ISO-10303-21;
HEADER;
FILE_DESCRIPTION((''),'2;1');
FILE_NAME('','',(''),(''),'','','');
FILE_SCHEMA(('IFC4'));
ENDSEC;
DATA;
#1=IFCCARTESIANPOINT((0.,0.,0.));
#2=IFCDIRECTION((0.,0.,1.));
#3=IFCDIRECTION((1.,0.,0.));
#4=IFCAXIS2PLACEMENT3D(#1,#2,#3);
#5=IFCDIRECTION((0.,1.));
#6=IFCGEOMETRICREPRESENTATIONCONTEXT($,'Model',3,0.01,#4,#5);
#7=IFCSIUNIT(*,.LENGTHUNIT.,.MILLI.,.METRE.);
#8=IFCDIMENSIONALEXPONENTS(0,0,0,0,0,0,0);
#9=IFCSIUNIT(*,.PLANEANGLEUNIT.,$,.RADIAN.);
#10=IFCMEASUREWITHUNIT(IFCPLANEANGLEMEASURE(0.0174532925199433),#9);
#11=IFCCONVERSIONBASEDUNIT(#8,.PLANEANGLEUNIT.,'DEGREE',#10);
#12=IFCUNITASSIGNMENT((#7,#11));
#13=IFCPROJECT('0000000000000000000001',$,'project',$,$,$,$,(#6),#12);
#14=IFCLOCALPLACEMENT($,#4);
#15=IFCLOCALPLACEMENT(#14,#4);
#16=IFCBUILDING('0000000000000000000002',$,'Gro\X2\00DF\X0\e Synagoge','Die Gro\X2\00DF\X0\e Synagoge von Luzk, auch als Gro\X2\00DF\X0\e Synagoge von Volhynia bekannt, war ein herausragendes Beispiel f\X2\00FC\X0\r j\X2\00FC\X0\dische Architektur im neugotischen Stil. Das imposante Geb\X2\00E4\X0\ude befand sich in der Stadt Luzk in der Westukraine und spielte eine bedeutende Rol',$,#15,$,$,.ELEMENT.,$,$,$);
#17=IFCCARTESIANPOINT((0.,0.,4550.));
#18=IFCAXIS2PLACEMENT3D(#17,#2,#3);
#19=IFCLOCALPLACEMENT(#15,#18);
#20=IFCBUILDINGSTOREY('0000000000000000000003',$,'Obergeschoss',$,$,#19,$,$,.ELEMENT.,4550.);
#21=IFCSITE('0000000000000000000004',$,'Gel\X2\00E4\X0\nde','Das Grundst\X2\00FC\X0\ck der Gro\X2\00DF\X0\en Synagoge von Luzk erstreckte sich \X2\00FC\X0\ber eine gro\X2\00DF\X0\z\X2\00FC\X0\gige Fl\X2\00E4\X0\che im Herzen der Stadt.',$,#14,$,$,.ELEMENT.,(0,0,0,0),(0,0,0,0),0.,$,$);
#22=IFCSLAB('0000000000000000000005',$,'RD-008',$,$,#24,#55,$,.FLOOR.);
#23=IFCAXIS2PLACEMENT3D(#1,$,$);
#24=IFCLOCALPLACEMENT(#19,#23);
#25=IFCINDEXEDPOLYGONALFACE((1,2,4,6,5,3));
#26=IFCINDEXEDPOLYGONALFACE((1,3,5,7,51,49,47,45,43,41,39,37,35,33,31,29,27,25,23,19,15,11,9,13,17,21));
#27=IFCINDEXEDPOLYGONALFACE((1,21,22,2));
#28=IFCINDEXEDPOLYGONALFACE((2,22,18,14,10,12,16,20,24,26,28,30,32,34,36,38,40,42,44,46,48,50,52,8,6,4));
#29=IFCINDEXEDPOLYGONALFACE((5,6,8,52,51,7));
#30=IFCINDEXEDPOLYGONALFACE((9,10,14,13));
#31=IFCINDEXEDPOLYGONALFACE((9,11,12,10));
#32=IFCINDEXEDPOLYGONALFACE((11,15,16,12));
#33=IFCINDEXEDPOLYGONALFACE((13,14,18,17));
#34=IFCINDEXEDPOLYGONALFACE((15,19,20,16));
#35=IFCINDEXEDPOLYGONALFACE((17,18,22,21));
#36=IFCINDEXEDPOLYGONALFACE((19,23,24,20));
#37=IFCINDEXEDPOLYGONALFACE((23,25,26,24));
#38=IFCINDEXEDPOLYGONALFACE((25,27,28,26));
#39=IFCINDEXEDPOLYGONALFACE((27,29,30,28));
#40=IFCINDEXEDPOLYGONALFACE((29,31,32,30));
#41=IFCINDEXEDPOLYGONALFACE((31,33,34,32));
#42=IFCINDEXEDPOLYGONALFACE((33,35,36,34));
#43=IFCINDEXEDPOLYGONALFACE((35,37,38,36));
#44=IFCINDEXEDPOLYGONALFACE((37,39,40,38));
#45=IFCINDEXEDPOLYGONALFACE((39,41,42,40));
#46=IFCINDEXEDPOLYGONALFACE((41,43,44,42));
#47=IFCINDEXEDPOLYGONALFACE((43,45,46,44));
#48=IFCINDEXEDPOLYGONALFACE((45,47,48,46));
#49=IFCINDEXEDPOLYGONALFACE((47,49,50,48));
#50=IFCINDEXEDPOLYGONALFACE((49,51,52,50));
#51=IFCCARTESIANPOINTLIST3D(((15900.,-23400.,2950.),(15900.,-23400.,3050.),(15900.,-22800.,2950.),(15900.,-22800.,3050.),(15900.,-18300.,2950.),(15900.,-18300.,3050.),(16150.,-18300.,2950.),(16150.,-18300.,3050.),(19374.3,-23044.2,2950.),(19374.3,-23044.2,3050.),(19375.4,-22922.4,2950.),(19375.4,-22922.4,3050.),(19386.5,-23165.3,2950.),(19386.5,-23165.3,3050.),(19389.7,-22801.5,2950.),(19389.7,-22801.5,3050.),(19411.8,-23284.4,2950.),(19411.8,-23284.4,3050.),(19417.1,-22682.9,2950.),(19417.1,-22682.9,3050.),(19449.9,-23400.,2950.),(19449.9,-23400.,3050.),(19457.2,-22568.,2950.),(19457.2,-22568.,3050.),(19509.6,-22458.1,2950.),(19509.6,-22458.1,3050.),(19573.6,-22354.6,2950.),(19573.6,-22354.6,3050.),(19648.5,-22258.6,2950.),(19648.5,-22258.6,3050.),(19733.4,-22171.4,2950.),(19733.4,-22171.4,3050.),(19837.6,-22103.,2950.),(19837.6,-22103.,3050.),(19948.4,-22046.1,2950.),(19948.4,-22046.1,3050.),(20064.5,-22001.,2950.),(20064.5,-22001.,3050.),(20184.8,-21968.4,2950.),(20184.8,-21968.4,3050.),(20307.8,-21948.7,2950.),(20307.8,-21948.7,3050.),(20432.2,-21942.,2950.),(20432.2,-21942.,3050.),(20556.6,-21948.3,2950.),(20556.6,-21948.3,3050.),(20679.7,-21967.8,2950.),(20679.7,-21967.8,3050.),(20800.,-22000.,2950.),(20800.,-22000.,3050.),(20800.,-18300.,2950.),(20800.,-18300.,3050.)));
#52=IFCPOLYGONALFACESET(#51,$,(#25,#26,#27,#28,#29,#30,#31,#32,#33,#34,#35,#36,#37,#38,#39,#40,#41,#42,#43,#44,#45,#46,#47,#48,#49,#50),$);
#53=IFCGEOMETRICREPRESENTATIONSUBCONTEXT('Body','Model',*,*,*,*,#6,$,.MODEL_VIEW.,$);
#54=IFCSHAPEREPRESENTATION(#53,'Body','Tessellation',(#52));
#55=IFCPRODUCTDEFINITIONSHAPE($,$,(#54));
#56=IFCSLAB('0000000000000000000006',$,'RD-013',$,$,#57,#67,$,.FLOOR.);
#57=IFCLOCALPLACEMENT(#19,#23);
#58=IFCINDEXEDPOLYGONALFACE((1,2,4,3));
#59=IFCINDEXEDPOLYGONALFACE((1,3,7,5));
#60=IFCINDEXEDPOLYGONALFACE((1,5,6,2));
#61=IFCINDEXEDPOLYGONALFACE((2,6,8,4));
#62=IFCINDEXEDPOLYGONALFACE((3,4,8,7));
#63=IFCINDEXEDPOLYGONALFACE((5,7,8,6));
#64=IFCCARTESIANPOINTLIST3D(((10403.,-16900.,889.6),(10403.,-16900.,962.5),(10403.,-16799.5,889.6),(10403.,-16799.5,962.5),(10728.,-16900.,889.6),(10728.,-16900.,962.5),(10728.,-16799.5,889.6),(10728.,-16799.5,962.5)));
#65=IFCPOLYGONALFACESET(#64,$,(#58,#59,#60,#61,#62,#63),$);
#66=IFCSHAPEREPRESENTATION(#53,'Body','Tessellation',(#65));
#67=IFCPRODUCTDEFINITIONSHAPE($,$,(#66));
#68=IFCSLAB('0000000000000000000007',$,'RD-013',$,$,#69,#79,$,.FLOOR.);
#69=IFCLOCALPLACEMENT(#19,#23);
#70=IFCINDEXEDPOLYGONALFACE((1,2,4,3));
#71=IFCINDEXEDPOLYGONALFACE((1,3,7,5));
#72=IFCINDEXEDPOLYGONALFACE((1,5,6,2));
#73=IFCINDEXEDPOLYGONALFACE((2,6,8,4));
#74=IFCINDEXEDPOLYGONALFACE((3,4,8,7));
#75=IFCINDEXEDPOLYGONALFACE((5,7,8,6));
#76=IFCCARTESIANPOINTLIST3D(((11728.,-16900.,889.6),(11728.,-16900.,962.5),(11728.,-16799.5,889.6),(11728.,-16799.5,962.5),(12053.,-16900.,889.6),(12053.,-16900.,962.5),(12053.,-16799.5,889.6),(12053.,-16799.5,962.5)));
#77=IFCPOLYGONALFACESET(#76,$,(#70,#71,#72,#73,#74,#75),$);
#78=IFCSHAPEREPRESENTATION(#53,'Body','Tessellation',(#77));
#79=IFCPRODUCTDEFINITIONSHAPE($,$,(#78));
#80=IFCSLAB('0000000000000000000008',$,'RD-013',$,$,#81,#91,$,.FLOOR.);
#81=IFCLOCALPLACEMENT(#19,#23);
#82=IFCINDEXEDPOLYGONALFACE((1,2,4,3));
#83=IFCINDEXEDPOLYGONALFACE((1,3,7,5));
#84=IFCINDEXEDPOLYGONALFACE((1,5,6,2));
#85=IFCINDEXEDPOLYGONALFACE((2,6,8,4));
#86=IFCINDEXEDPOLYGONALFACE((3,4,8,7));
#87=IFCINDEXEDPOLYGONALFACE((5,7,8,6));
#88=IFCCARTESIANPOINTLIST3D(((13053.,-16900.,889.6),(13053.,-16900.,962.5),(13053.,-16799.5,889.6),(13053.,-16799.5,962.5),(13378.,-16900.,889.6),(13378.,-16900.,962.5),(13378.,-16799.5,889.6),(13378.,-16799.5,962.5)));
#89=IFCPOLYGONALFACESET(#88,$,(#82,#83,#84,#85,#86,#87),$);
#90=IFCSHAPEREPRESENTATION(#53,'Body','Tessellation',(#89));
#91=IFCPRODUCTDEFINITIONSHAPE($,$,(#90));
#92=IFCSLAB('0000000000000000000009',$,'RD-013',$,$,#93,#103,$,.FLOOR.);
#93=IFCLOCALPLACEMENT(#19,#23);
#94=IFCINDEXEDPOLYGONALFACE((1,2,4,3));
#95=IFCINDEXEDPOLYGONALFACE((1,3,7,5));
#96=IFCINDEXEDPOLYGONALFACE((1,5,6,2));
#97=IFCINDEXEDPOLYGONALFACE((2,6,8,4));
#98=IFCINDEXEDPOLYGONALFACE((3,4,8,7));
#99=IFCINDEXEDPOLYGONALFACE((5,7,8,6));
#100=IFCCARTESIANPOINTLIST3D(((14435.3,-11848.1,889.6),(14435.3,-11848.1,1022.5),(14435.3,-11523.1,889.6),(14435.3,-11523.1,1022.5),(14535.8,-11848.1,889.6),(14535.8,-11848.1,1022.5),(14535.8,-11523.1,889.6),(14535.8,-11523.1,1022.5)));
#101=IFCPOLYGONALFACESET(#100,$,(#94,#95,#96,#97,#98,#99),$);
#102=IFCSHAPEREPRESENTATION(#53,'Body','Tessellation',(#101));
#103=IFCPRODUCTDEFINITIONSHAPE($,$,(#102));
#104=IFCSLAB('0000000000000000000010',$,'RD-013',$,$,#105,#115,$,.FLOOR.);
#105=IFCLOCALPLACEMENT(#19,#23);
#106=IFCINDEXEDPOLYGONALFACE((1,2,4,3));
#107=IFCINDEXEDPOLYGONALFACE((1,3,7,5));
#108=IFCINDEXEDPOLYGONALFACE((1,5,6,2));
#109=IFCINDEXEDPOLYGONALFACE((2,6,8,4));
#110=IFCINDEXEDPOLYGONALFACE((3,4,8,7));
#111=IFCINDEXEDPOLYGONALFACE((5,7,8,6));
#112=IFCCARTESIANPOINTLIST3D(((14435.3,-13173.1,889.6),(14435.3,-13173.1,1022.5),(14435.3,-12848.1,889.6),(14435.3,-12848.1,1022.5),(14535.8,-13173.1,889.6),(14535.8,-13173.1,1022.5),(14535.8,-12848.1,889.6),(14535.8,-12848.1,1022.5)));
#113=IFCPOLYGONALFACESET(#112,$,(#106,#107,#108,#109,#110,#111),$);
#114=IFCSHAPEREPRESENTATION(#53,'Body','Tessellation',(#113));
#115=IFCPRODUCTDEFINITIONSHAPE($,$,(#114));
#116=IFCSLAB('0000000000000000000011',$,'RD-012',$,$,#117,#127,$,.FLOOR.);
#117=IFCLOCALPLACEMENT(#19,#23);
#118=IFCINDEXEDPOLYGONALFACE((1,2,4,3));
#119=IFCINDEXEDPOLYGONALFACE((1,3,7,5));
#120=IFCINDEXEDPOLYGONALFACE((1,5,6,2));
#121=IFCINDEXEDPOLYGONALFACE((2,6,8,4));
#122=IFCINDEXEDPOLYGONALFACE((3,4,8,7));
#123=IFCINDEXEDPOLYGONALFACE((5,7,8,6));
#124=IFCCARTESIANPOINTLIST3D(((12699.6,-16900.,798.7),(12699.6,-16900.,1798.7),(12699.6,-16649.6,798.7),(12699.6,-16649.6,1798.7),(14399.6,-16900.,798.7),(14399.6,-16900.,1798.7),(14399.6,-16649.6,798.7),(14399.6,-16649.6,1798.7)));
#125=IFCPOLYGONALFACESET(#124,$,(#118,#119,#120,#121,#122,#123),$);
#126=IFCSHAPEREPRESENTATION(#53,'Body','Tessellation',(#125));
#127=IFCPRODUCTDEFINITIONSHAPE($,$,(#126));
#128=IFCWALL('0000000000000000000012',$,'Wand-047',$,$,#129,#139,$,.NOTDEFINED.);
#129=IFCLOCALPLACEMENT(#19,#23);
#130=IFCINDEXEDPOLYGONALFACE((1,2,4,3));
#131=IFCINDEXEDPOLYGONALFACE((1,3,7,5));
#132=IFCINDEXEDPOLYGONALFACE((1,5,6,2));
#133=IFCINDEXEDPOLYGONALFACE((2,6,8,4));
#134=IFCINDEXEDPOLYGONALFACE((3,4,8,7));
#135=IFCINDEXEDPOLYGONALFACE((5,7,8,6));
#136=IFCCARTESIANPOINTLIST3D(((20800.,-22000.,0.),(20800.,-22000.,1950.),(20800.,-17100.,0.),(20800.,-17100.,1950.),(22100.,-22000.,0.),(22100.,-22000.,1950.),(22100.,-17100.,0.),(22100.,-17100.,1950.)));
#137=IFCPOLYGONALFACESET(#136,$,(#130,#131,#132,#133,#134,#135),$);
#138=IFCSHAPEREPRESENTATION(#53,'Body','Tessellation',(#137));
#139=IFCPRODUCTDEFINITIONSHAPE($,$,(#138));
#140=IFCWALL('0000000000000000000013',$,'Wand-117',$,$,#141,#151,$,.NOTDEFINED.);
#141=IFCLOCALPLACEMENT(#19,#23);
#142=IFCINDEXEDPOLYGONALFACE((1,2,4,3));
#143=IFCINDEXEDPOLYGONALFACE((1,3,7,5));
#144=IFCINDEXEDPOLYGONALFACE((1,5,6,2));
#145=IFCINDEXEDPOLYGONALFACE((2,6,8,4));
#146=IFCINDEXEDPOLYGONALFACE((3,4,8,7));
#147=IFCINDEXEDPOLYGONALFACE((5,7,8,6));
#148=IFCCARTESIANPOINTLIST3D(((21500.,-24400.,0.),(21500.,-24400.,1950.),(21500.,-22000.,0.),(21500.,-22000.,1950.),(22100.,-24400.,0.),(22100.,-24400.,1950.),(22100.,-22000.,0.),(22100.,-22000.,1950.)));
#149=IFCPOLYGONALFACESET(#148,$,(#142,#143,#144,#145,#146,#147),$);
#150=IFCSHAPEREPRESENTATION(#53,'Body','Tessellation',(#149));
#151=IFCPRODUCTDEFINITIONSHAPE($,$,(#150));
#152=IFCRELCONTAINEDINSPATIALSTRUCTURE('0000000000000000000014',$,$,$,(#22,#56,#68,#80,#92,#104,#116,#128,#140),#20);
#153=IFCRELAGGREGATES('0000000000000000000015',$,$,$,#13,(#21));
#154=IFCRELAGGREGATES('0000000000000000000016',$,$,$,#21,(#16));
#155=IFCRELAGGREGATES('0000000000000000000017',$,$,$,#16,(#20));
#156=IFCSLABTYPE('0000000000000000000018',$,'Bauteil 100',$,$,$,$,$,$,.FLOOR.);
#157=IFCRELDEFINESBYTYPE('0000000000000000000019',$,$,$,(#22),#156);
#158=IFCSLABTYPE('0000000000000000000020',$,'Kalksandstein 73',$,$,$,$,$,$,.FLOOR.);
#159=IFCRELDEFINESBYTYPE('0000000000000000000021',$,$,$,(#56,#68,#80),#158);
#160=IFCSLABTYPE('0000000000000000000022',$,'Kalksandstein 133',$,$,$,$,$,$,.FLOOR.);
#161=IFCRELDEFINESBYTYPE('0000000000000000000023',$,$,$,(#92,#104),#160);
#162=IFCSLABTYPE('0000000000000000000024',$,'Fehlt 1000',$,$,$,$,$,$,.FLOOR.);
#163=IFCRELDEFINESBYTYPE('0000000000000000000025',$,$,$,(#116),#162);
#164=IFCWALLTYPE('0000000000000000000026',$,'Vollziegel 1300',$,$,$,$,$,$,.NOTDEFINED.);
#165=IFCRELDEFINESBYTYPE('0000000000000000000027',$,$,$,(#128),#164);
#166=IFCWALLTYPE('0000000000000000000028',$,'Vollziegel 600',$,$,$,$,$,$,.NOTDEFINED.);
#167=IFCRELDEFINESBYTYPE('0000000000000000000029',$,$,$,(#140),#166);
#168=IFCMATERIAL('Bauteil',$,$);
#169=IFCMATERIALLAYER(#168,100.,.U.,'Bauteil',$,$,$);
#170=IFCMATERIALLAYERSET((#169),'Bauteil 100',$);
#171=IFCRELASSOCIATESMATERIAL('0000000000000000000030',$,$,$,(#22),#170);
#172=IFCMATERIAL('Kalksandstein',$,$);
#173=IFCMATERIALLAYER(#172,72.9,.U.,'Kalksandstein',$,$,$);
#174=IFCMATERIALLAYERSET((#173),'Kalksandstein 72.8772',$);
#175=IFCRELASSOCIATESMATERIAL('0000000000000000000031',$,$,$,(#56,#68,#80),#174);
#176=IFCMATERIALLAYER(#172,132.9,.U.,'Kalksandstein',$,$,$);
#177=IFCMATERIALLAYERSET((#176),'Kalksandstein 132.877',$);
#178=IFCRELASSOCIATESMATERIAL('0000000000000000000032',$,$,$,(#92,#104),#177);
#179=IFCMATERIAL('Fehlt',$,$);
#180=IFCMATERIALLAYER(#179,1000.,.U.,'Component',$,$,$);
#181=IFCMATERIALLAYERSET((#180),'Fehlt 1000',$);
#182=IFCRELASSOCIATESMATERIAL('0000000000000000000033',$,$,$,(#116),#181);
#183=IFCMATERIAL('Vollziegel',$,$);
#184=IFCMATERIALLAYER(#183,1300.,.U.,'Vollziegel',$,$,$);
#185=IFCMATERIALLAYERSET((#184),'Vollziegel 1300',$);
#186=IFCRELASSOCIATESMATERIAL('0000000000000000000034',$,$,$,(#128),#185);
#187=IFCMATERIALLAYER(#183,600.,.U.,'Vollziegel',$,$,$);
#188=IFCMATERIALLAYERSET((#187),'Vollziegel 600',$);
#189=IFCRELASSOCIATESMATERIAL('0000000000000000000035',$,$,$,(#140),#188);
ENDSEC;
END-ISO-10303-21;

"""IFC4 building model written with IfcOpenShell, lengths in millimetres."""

from ifc_helpers import new_model, entity, si_unit, converted_unit, direction, frame, origin_with_axes, place, context, subcontext, project, spatial, line, arc, indexed_curve, outline, extrude, material, layer, layer_set, layer_usage, type_object, element, save


model = new_model("IFC4")

# Units and contexts
model_context = context("Model", 3, precision=0.01, world=origin_with_axes(), true_north=direction((0.0, 1.0)))
body_context = subcontext(model_context, "Body", "Model", "MODEL_VIEW")
ifc_project = project(units=[si_unit("LENGTHUNIT", "METRE", prefix="MILLI"), converted_unit("PLANEANGLEUNIT", "DEGREE", entity("IfcPlaneAngleMeasure", 0.0174532925199433), si_unit("PLANEANGLEUNIT", "RADIAN"), dimensions=[0, 0, 0, 0, 0, 0, 0])], contexts=[model_context])

# Site, building, storey
site_placement = place(None, origin_with_axes())
site = spatial("IfcSite", under=ifc_project, at=site_placement, Name="Gelände", Description="Das Grundstück der Großen Synagoge von Luzk erstreckte sich über eine großzügige Fläche im Herzen der Stadt.", CompositionType="ELEMENT", RefLatitude=(0, 0, 0, 0), RefLongitude=(0, 0, 0, 0), RefElevation=0.0)
building_placement = place(site_placement, origin_with_axes())
building = spatial("IfcBuilding", under=site, at=building_placement, Name="Große Synagoge", Description="Die Große Synagoge von Luzk, auch als Große Synagoge von Volhynia bekannt, war ein herausragendes Beispiel für jüdische Architektur im neugotischen Stil. Das imposante Gebäude befand sich in der Stadt Luzk in der Westukraine und spielte eine bedeutende Rol", CompositionType="ELEMENT")
storey_placement = place(building_placement, frame((0.0, 0.0, 4550.0), z_axis=(0.0, 0.0, 1.0), x_axis=(1.0, 0.0, 0.0)))
storey = spatial("IfcBuildingStorey", under=building, at=storey_placement, Name="Obergeschoss", CompositionType="ELEMENT", Elevation=4550.0)

# Shared definitions
ifc_material_1 = material(Name="Kalksandstein")

# Slabs
ifc_material_2 = material(Name="Bauteil")
ifc_layer_1 = layer(ifc_material_2, 100.0, ventilated="UNKNOWN", Name="Bauteil")
ifc_layer_set_1 = layer_set([ifc_layer_1], Name="Bauteil 100")
ifc_layer_usage_1 = layer_usage(ifc_layer_set_1, "AXIS3", "NEGATIVE", 100.0)
slab_type_1 = type_object("IfcSlabType", Name="Bauteil 100", PredefinedType="FLOOR")
slab_1_placement = place(storey_placement, frame((15900.0, -18300.0, 3050.0), z_axis=(0.0, 0.0, 1.0), x_axis=(1.0, 0.0, 0.0)))
element("IfcSlab", 1, at=slab_1_placement, inside=storey, type_object=slab_type_1, material=ifc_layer_usage_1, Name="RD-008", PredefinedType="FLOOR", context=body_context, shape_type="SweptSolid", body=[
    extrude(outline(indexed_curve([(0.0, 0.0), (0.0, -4500.0), (0.0, -5100.0), (3549.9, -5100.0), (3501.8, -4441.9), (3833.4, -3871.4), (4346.0, -3656.9), (4900.0, -3700.0), (4900.0, 0.0), (250.0, 0.0)], segments=[line(1, 2, 3, 4), arc(4, 5, 6), arc(6, 7, 8), line(8, 9, 10, 1)])), frame((0.0, 0.0, -100.0), z_axis=(0.0, 0.0, 1.0), x_axis=(1.0, 0.0, 0.0)), (0.0, 0.0, 1.0), 100.0),
])
ifc_layer_2 = layer(ifc_material_1, 72.9, ventilated="UNKNOWN", Name="Kalksandstein")
ifc_layer_set_2 = layer_set([ifc_layer_2], Name="Kalksandstein 72.8772")
ifc_layer_usage_2 = layer_usage(ifc_layer_set_2, "AXIS3", "NEGATIVE", 72.9)
slab_type_2 = type_object("IfcSlabType", Name="Kalksandstein 73", PredefinedType="FLOOR")
slab_2_placement = place(storey_placement, frame((10403.0, -16900.0, 962.5), z_axis=(0.0, 0.0, 1.0), x_axis=(1.0, 0.0, 0.0)))
element("IfcSlab", 2, at=slab_2_placement, inside=storey, type_object=slab_type_2, material=ifc_layer_usage_2, Name="RD-013", PredefinedType="FLOOR", context=body_context, shape_type="SweptSolid", body=[
    extrude(outline(indexed_curve([(0.0, 0.0), (325.0, 0.0), (325.0, 100.5), (0.0, 100.5)], segments=[line(1, 2, 3, 4, 1)])), frame((0.0, 0.0, -72.9), z_axis=(0.0, 0.0, 1.0), x_axis=(1.0, 0.0, 0.0)), (0.0, 0.0, 1.0), 72.9),
])
ifc_layer_usage_3 = layer_usage(ifc_layer_set_2, "AXIS3", "NEGATIVE", 72.9)
slab_3_placement = place(storey_placement, frame((11728.0, -16900.0, 962.5), z_axis=(0.0, 0.0, 1.0), x_axis=(1.0, 0.0, 0.0)))
element("IfcSlab", 3, at=slab_3_placement, inside=storey, type_object=slab_type_2, material=ifc_layer_usage_3, Name="RD-013", PredefinedType="FLOOR", context=body_context, shape_type="SweptSolid", body=[
    extrude(outline(indexed_curve([(0.0, 0.0), (325.0, 0.0), (325.0, 100.5), (0.0, 100.5)], segments=[line(1, 2, 3, 4, 1)])), frame((0.0, 0.0, -72.9), z_axis=(0.0, 0.0, 1.0), x_axis=(1.0, 0.0, 0.0)), (0.0, 0.0, 1.0), 72.9),
])
ifc_layer_usage_4 = layer_usage(ifc_layer_set_2, "AXIS3", "NEGATIVE", 72.9)
slab_4_placement = place(storey_placement, frame((13053.0, -16900.0, 962.5), z_axis=(0.0, 0.0, 1.0), x_axis=(1.0, 0.0, 0.0)))
element("IfcSlab", 4, at=slab_4_placement, inside=storey, type_object=slab_type_2, material=ifc_layer_usage_4, Name="RD-013", PredefinedType="FLOOR", context=body_context, shape_type="SweptSolid", body=[
    extrude(outline(indexed_curve([(0.0, 0.0), (325.0, 0.0), (325.0, 100.5), (0.0, 100.5)], segments=[line(1, 2, 3, 4, 1)])), frame((0.0, 0.0, -72.9), z_axis=(0.0, 0.0, 1.0), x_axis=(1.0, 0.0, 0.0)), (0.0, 0.0, 1.0), 72.9),
])
ifc_layer_3 = layer(ifc_material_1, 132.9, ventilated="UNKNOWN", Name="Kalksandstein")
ifc_layer_set_3 = layer_set([ifc_layer_3], Name="Kalksandstein 132.877")
ifc_layer_usage_5 = layer_usage(ifc_layer_set_3, "AXIS3", "NEGATIVE", 132.9)
slab_type_3 = type_object("IfcSlabType", Name="Kalksandstein 133", PredefinedType="FLOOR")
slab_5_placement = place(storey_placement, frame((14435.3, -11523.1, 1022.5), z_axis=(0.0, 0.0, 1.0), x_axis=(1.0, 0.0, 0.0)))
element("IfcSlab", 5, at=slab_5_placement, inside=storey, type_object=slab_type_3, material=ifc_layer_usage_5, Name="RD-013", PredefinedType="FLOOR", context=body_context, shape_type="SweptSolid", body=[
    extrude(outline(indexed_curve([(0.0, 0.0), (0.0, -325.0), (100.5, -325.0), (100.5, 0.0)], segments=[line(1, 2, 3, 4, 1)])), frame((0.0, 0.0, -132.9), z_axis=(0.0, 0.0, 1.0), x_axis=(1.0, 0.0, 0.0)), (0.0, 0.0, 1.0), 132.9),
])
ifc_layer_usage_6 = layer_usage(ifc_layer_set_3, "AXIS3", "NEGATIVE", 132.9)
slab_6_placement = place(storey_placement, frame((14435.3, -12848.1, 1022.5), z_axis=(0.0, 0.0, 1.0), x_axis=(1.0, 0.0, 0.0)))
element("IfcSlab", 6, at=slab_6_placement, inside=storey, type_object=slab_type_3, material=ifc_layer_usage_6, Name="RD-013", PredefinedType="FLOOR", context=body_context, shape_type="SweptSolid", body=[
    extrude(outline(indexed_curve([(0.0, 0.0), (0.0, -325.0), (100.5, -325.0), (100.5, 0.0)], segments=[line(1, 2, 3, 4, 1)])), frame((0.0, 0.0, -132.9), z_axis=(0.0, 0.0, 1.0), x_axis=(1.0, 0.0, 0.0)), (0.0, 0.0, 1.0), 132.9),
])
ifc_material_3 = material(Name="Fehlt")
ifc_layer_4 = layer(ifc_material_3, 1000.0, ventilated="UNKNOWN", Name="Component")
ifc_layer_set_4 = layer_set([ifc_layer_4], Name="Fehlt 1000")
ifc_layer_usage_7 = layer_usage(ifc_layer_set_4, "AXIS3", "NEGATIVE", 1000.0)
slab_type_4 = type_object("IfcSlabType", Name="Fehlt 1000", PredefinedType="FLOOR")
slab_7_placement = place(storey_placement, frame((14399.6, -16900.0, 1798.7), z_axis=(0.0, 0.0, 1.0), x_axis=(1.0, 0.0, 0.0)))
element("IfcSlab", 7, at=slab_7_placement, inside=storey, type_object=slab_type_4, material=ifc_layer_usage_7, Name="RD-012", PredefinedType="FLOOR", context=body_context, shape_type="SweptSolid", body=[
    extrude(outline(indexed_curve([(0.0, 0.0), (0.0, 250.4), (-1700.0, 250.4), (-1700.0, 0.0)], segments=[line(1, 2, 3, 4, 1)])), frame((0.0, 0.0, -1000.0), z_axis=(0.0, 0.0, 1.0), x_axis=(1.0, 0.0, 0.0)), (0.0, 0.0, 1.0), 1000.0),
])

# Shared definitions
ifc_material_4 = material(Name="Vollziegel")

# Walls
ifc_layer_5 = layer(ifc_material_4, 1300.0, ventilated="UNKNOWN", Name="Vollziegel")
ifc_layer_set_5 = layer_set([ifc_layer_5], Name="Vollziegel 1300")
ifc_layer_usage_8 = layer_usage(ifc_layer_set_5, "AXIS2", "POSITIVE", -1300.0)
wall_type_1 = type_object("IfcWallType", Name="Vollziegel 1300", PredefinedType="NOTDEFINED")
wall_1_placement = place(storey_placement, frame((22100.0, -17100.0, 0.0), z_axis=(0.0, 0.0, 1.0), x_axis=(0.0, -1.0, 0.0)))
element("IfcWall", 8, at=wall_1_placement, inside=storey, type_object=wall_type_1, material=ifc_layer_usage_8, Name="Wand-047", PredefinedType="NOTDEFINED", context=body_context, shape_type="SweptSolid", body=[
    extrude(outline(indexed_curve([(0.0, -1300.0), (4900.0, -1300.0), (4900.0, 0.0), (0.0, 0.0)], segments=[line(1, 2, 3, 4, 1)])), origin_with_axes(), (0.0, 0.0, 1.0), 1950.0),
])
ifc_layer_6 = layer(ifc_material_4, 600.0, ventilated="UNKNOWN", Name="Vollziegel")
ifc_layer_set_6 = layer_set([ifc_layer_6], Name="Vollziegel 600")
wall_type_2 = type_object("IfcWallType", Name="Vollziegel 600", PredefinedType="NOTDEFINED")
ifc_layer_usage_9 = layer_usage(ifc_layer_set_6, "AXIS2", "POSITIVE", -600.0)
wall_2_placement = place(storey_placement, frame((22100.0, -22000.0, 0.0), z_axis=(0.0, 0.0, 1.0), x_axis=(0.0, -1.0, 0.0)))
element("IfcWall", 9, at=wall_2_placement, inside=storey, type_object=wall_type_2, material=ifc_layer_usage_9, Name="Wand-117", PredefinedType="NOTDEFINED", context=body_context, shape_type="SweptSolid", body=[
    extrude(outline(indexed_curve([(0.0, -600.0), (2400.0, -600.0), (2400.0, 0.0), (0.0, 0.0)], segments=[line(1, 2, 3, 4, 1)])), origin_with_axes(), (0.0, 0.0, 1.0), 1950.0),
])

save(model, "model.ifc")
